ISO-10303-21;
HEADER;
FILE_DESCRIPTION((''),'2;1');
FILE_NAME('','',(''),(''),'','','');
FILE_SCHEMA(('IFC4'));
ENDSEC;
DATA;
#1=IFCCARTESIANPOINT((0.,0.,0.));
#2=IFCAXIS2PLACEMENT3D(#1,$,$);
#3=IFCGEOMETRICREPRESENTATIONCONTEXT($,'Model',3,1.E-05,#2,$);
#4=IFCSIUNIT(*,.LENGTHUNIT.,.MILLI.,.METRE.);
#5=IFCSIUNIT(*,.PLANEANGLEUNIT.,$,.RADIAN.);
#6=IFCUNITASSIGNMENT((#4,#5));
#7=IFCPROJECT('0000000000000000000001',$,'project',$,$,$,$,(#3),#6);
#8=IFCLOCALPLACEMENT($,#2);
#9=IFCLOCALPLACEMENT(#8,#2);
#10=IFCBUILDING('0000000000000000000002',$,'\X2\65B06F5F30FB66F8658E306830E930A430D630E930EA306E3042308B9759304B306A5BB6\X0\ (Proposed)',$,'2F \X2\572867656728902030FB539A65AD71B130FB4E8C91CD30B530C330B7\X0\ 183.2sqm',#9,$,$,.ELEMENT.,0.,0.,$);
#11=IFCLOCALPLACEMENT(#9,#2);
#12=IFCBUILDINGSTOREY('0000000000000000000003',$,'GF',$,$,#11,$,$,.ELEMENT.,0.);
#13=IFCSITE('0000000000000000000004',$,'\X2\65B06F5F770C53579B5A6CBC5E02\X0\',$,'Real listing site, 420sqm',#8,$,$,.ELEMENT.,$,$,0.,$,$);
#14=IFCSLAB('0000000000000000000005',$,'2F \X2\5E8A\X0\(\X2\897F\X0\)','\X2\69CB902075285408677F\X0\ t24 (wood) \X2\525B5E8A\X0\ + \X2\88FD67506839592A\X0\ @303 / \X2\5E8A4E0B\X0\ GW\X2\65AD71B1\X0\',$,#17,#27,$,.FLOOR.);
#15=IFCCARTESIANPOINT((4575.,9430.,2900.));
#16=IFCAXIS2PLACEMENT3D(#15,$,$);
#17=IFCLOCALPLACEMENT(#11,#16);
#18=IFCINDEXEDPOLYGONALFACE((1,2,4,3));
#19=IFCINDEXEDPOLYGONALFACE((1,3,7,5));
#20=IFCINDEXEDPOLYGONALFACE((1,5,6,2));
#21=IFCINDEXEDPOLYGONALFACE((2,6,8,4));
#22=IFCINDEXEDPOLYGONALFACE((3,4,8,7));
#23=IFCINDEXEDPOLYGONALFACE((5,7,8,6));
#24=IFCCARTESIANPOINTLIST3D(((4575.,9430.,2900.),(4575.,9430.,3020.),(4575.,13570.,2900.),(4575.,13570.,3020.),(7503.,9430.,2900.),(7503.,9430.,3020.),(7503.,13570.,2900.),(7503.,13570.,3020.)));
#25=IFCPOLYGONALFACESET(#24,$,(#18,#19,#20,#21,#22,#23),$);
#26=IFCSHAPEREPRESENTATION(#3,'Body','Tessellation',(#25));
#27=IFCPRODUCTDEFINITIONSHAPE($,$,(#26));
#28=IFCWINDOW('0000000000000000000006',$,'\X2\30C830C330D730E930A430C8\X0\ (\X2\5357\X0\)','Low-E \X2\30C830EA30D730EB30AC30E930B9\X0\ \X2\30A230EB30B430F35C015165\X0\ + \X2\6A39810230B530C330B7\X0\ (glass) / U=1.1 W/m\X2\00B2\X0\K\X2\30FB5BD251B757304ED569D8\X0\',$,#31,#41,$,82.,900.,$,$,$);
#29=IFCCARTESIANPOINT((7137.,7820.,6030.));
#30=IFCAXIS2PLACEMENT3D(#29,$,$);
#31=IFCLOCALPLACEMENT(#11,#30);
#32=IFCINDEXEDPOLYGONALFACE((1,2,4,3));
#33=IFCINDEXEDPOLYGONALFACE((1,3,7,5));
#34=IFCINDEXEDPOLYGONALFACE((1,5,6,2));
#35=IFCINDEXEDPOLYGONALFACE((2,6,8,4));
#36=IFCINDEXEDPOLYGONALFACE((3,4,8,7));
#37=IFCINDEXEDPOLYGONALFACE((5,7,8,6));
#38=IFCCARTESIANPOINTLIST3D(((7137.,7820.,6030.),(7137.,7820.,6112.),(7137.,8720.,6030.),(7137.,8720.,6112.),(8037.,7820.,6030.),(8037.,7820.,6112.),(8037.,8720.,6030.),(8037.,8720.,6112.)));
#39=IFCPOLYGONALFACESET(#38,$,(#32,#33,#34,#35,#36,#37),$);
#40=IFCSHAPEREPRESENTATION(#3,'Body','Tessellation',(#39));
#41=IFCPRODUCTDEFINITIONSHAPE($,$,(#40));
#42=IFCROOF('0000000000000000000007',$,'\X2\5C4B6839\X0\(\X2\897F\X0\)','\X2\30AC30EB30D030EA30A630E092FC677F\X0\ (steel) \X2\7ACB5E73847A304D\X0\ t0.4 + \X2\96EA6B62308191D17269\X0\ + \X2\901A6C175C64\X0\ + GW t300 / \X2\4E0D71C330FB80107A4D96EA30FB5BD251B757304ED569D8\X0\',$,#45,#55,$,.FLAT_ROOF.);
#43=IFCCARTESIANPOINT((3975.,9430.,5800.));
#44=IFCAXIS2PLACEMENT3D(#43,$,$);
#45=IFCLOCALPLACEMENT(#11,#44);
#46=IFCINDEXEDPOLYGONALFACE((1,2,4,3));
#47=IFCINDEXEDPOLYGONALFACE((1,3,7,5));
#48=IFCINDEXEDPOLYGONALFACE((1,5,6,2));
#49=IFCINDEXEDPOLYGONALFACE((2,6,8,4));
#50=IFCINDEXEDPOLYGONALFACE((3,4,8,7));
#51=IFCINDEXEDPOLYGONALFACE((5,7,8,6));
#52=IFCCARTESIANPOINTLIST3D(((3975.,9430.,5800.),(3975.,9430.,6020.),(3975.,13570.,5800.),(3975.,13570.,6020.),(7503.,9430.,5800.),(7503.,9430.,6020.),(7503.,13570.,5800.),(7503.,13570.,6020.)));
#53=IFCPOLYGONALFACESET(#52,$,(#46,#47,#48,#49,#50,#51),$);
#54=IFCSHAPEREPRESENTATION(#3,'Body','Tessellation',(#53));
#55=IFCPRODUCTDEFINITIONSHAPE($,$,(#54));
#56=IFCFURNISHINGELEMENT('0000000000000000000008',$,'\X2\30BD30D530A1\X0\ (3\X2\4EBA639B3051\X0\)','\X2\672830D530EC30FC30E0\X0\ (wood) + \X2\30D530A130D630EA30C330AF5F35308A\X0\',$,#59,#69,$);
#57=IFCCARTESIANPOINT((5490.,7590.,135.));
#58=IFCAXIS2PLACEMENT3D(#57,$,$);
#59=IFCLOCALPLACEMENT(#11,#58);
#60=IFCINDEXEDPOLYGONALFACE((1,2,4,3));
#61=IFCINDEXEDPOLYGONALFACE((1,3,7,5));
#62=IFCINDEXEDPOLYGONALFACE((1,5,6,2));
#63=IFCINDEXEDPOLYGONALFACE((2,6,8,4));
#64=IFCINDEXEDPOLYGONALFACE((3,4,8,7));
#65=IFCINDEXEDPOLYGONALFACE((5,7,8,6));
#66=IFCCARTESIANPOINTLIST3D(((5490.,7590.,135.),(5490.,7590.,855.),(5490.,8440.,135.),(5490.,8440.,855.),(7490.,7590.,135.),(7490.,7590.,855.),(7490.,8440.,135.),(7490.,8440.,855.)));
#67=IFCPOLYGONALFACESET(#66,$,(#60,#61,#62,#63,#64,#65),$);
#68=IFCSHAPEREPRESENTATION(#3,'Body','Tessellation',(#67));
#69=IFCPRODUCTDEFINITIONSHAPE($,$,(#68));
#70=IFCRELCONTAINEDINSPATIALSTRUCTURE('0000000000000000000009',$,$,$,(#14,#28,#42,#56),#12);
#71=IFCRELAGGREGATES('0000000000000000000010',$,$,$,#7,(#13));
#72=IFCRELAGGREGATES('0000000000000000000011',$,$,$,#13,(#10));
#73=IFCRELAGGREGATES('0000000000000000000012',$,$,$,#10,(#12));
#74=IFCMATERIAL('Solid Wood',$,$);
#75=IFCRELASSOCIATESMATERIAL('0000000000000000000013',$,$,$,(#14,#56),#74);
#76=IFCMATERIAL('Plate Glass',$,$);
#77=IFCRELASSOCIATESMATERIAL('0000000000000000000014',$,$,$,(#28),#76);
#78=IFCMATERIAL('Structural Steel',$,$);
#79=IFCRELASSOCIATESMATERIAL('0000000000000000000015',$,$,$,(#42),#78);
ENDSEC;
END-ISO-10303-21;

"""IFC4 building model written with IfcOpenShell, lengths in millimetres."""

from ifc_helpers import new_model, si_unit, frame, frame_2d, origin, place, context, project, spatial, rectangle, extrude, material, element, save


model = new_model("IFC4")

# Units and contexts
model_context = context("Model", 3, precision=1e-05, world=origin())
ifc_project = project(units=[si_unit("LENGTHUNIT", "METRE", prefix="MILLI"), si_unit("PLANEANGLEUNIT", "RADIAN")], contexts=[model_context])

# Site, building, storey
site_placement = place(None, origin())
site = spatial("IfcSite", under=ifc_project, at=site_placement, Name="新潟県南魚沼市", ObjectType="Real listing site, 420sqm", CompositionType="ELEMENT", RefElevation=0.0)
building_placement = place(site_placement, origin())
building = spatial("IfcBuilding", under=site, at=building_placement, Name="新潟・書斎とライブラリのある静かな家 (Proposed)", ObjectType="2F 在来木造・厚断熱・二重サッシ 183.2sqm", CompositionType="ELEMENT", ElevationOfRefHeight=0.0, ElevationOfTerrain=0.0)
storey_placement = place(building_placement, origin())
storey = spatial("IfcBuildingStorey", under=building, at=storey_placement, Name="GF", CompositionType="ELEMENT", Elevation=0.0)

# Shared definitions
ifc_material_1 = material(Name="Solid Wood")

# Slab
slab_1_placement = place(storey_placement, frame((4575.0, 9430.0, 2900.0)))
element("IfcSlab", 1, at=slab_1_placement, inside=storey, material=ifc_material_1, Name="2F 床(西)", Description="構造用合板 t24 (wood) 剛床 + 製材根太 @303 / 床下 GW断熱", PredefinedType="FLOOR", context=model_context, shape_type="SweptSolid", body=[
    extrude(rectangle(XDim=2928.0, YDim=4140.0, at=frame_2d((1464.0, 2070.0))), frame((4575.0, 9430.0, 2900.0)), (0.0, 0.0, 1.0), 120.0),
])

# Window
ifc_material_2 = material(Name="Plate Glass")
window_placement = place(storey_placement, frame((7137.0, 7820.0, 6030.0)))
element("IfcWindow", 2, at=window_placement, inside=storey, material=ifc_material_2, Name="トップライト (南)", Description="Low-E トリプルガラス アルゴン封入 + 樹脂サッシ (glass) / U=1.1 W/m²K・寒冷地仕様", OverallHeight=82.0, OverallWidth=900.0, context=model_context, shape_type="SweptSolid", body=[
    extrude(rectangle(XDim=900.0, YDim=900.0, at=frame_2d((450.0, 450.0))), frame((7137.0, 7820.0, 6030.0)), (0.0, 0.0, 1.0), 82.0),
])

# Roof
ifc_material_3 = material(Name="Structural Steel")
for number, where, name in (
    (3, (3975.0, 9430.0, 5800.0), "屋根(西)"),
):
    element("IfcRoof", number, at=place(storey_placement, frame(where)), inside=storey, material=ifc_material_3, Name=name, Description="ガルバリウム鋼板 (steel) 立平葺き t0.4 + 雪止め金物 + 通気層 + GW t300 / 不燃・耐積雪・寒冷地仕様", PredefinedType="FLAT_ROOF", context=model_context, shape_type="SweptSolid", body=[
        extrude(rectangle(XDim=3528.0, YDim=4140.0, at=frame_2d((1764.0, 2070.0))), frame((3975.0, 9430.0, 5800.0)), (0.0, 0.0, 1.0), 220.0),
    ])

# Furnishing element
furnishing_placement = place(storey_placement, frame((5490.0, 7590.0, 135.0)))
element("IfcFurnishingElement", 4, at=furnishing_placement, inside=storey, material=ifc_material_1, Name="ソファ (3人掛け)", Description="木フレーム (wood) + ファブリック張り", context=model_context, shape_type="SweptSolid", body=[
    extrude(rectangle(XDim=2000.0, YDim=850.0, at=frame_2d((1000.0, 425.0))), frame((5490.0, 7590.0, 135.0)), (0.0, 0.0, 1.0), 720.0),
])

save(model, "model.ifc")
